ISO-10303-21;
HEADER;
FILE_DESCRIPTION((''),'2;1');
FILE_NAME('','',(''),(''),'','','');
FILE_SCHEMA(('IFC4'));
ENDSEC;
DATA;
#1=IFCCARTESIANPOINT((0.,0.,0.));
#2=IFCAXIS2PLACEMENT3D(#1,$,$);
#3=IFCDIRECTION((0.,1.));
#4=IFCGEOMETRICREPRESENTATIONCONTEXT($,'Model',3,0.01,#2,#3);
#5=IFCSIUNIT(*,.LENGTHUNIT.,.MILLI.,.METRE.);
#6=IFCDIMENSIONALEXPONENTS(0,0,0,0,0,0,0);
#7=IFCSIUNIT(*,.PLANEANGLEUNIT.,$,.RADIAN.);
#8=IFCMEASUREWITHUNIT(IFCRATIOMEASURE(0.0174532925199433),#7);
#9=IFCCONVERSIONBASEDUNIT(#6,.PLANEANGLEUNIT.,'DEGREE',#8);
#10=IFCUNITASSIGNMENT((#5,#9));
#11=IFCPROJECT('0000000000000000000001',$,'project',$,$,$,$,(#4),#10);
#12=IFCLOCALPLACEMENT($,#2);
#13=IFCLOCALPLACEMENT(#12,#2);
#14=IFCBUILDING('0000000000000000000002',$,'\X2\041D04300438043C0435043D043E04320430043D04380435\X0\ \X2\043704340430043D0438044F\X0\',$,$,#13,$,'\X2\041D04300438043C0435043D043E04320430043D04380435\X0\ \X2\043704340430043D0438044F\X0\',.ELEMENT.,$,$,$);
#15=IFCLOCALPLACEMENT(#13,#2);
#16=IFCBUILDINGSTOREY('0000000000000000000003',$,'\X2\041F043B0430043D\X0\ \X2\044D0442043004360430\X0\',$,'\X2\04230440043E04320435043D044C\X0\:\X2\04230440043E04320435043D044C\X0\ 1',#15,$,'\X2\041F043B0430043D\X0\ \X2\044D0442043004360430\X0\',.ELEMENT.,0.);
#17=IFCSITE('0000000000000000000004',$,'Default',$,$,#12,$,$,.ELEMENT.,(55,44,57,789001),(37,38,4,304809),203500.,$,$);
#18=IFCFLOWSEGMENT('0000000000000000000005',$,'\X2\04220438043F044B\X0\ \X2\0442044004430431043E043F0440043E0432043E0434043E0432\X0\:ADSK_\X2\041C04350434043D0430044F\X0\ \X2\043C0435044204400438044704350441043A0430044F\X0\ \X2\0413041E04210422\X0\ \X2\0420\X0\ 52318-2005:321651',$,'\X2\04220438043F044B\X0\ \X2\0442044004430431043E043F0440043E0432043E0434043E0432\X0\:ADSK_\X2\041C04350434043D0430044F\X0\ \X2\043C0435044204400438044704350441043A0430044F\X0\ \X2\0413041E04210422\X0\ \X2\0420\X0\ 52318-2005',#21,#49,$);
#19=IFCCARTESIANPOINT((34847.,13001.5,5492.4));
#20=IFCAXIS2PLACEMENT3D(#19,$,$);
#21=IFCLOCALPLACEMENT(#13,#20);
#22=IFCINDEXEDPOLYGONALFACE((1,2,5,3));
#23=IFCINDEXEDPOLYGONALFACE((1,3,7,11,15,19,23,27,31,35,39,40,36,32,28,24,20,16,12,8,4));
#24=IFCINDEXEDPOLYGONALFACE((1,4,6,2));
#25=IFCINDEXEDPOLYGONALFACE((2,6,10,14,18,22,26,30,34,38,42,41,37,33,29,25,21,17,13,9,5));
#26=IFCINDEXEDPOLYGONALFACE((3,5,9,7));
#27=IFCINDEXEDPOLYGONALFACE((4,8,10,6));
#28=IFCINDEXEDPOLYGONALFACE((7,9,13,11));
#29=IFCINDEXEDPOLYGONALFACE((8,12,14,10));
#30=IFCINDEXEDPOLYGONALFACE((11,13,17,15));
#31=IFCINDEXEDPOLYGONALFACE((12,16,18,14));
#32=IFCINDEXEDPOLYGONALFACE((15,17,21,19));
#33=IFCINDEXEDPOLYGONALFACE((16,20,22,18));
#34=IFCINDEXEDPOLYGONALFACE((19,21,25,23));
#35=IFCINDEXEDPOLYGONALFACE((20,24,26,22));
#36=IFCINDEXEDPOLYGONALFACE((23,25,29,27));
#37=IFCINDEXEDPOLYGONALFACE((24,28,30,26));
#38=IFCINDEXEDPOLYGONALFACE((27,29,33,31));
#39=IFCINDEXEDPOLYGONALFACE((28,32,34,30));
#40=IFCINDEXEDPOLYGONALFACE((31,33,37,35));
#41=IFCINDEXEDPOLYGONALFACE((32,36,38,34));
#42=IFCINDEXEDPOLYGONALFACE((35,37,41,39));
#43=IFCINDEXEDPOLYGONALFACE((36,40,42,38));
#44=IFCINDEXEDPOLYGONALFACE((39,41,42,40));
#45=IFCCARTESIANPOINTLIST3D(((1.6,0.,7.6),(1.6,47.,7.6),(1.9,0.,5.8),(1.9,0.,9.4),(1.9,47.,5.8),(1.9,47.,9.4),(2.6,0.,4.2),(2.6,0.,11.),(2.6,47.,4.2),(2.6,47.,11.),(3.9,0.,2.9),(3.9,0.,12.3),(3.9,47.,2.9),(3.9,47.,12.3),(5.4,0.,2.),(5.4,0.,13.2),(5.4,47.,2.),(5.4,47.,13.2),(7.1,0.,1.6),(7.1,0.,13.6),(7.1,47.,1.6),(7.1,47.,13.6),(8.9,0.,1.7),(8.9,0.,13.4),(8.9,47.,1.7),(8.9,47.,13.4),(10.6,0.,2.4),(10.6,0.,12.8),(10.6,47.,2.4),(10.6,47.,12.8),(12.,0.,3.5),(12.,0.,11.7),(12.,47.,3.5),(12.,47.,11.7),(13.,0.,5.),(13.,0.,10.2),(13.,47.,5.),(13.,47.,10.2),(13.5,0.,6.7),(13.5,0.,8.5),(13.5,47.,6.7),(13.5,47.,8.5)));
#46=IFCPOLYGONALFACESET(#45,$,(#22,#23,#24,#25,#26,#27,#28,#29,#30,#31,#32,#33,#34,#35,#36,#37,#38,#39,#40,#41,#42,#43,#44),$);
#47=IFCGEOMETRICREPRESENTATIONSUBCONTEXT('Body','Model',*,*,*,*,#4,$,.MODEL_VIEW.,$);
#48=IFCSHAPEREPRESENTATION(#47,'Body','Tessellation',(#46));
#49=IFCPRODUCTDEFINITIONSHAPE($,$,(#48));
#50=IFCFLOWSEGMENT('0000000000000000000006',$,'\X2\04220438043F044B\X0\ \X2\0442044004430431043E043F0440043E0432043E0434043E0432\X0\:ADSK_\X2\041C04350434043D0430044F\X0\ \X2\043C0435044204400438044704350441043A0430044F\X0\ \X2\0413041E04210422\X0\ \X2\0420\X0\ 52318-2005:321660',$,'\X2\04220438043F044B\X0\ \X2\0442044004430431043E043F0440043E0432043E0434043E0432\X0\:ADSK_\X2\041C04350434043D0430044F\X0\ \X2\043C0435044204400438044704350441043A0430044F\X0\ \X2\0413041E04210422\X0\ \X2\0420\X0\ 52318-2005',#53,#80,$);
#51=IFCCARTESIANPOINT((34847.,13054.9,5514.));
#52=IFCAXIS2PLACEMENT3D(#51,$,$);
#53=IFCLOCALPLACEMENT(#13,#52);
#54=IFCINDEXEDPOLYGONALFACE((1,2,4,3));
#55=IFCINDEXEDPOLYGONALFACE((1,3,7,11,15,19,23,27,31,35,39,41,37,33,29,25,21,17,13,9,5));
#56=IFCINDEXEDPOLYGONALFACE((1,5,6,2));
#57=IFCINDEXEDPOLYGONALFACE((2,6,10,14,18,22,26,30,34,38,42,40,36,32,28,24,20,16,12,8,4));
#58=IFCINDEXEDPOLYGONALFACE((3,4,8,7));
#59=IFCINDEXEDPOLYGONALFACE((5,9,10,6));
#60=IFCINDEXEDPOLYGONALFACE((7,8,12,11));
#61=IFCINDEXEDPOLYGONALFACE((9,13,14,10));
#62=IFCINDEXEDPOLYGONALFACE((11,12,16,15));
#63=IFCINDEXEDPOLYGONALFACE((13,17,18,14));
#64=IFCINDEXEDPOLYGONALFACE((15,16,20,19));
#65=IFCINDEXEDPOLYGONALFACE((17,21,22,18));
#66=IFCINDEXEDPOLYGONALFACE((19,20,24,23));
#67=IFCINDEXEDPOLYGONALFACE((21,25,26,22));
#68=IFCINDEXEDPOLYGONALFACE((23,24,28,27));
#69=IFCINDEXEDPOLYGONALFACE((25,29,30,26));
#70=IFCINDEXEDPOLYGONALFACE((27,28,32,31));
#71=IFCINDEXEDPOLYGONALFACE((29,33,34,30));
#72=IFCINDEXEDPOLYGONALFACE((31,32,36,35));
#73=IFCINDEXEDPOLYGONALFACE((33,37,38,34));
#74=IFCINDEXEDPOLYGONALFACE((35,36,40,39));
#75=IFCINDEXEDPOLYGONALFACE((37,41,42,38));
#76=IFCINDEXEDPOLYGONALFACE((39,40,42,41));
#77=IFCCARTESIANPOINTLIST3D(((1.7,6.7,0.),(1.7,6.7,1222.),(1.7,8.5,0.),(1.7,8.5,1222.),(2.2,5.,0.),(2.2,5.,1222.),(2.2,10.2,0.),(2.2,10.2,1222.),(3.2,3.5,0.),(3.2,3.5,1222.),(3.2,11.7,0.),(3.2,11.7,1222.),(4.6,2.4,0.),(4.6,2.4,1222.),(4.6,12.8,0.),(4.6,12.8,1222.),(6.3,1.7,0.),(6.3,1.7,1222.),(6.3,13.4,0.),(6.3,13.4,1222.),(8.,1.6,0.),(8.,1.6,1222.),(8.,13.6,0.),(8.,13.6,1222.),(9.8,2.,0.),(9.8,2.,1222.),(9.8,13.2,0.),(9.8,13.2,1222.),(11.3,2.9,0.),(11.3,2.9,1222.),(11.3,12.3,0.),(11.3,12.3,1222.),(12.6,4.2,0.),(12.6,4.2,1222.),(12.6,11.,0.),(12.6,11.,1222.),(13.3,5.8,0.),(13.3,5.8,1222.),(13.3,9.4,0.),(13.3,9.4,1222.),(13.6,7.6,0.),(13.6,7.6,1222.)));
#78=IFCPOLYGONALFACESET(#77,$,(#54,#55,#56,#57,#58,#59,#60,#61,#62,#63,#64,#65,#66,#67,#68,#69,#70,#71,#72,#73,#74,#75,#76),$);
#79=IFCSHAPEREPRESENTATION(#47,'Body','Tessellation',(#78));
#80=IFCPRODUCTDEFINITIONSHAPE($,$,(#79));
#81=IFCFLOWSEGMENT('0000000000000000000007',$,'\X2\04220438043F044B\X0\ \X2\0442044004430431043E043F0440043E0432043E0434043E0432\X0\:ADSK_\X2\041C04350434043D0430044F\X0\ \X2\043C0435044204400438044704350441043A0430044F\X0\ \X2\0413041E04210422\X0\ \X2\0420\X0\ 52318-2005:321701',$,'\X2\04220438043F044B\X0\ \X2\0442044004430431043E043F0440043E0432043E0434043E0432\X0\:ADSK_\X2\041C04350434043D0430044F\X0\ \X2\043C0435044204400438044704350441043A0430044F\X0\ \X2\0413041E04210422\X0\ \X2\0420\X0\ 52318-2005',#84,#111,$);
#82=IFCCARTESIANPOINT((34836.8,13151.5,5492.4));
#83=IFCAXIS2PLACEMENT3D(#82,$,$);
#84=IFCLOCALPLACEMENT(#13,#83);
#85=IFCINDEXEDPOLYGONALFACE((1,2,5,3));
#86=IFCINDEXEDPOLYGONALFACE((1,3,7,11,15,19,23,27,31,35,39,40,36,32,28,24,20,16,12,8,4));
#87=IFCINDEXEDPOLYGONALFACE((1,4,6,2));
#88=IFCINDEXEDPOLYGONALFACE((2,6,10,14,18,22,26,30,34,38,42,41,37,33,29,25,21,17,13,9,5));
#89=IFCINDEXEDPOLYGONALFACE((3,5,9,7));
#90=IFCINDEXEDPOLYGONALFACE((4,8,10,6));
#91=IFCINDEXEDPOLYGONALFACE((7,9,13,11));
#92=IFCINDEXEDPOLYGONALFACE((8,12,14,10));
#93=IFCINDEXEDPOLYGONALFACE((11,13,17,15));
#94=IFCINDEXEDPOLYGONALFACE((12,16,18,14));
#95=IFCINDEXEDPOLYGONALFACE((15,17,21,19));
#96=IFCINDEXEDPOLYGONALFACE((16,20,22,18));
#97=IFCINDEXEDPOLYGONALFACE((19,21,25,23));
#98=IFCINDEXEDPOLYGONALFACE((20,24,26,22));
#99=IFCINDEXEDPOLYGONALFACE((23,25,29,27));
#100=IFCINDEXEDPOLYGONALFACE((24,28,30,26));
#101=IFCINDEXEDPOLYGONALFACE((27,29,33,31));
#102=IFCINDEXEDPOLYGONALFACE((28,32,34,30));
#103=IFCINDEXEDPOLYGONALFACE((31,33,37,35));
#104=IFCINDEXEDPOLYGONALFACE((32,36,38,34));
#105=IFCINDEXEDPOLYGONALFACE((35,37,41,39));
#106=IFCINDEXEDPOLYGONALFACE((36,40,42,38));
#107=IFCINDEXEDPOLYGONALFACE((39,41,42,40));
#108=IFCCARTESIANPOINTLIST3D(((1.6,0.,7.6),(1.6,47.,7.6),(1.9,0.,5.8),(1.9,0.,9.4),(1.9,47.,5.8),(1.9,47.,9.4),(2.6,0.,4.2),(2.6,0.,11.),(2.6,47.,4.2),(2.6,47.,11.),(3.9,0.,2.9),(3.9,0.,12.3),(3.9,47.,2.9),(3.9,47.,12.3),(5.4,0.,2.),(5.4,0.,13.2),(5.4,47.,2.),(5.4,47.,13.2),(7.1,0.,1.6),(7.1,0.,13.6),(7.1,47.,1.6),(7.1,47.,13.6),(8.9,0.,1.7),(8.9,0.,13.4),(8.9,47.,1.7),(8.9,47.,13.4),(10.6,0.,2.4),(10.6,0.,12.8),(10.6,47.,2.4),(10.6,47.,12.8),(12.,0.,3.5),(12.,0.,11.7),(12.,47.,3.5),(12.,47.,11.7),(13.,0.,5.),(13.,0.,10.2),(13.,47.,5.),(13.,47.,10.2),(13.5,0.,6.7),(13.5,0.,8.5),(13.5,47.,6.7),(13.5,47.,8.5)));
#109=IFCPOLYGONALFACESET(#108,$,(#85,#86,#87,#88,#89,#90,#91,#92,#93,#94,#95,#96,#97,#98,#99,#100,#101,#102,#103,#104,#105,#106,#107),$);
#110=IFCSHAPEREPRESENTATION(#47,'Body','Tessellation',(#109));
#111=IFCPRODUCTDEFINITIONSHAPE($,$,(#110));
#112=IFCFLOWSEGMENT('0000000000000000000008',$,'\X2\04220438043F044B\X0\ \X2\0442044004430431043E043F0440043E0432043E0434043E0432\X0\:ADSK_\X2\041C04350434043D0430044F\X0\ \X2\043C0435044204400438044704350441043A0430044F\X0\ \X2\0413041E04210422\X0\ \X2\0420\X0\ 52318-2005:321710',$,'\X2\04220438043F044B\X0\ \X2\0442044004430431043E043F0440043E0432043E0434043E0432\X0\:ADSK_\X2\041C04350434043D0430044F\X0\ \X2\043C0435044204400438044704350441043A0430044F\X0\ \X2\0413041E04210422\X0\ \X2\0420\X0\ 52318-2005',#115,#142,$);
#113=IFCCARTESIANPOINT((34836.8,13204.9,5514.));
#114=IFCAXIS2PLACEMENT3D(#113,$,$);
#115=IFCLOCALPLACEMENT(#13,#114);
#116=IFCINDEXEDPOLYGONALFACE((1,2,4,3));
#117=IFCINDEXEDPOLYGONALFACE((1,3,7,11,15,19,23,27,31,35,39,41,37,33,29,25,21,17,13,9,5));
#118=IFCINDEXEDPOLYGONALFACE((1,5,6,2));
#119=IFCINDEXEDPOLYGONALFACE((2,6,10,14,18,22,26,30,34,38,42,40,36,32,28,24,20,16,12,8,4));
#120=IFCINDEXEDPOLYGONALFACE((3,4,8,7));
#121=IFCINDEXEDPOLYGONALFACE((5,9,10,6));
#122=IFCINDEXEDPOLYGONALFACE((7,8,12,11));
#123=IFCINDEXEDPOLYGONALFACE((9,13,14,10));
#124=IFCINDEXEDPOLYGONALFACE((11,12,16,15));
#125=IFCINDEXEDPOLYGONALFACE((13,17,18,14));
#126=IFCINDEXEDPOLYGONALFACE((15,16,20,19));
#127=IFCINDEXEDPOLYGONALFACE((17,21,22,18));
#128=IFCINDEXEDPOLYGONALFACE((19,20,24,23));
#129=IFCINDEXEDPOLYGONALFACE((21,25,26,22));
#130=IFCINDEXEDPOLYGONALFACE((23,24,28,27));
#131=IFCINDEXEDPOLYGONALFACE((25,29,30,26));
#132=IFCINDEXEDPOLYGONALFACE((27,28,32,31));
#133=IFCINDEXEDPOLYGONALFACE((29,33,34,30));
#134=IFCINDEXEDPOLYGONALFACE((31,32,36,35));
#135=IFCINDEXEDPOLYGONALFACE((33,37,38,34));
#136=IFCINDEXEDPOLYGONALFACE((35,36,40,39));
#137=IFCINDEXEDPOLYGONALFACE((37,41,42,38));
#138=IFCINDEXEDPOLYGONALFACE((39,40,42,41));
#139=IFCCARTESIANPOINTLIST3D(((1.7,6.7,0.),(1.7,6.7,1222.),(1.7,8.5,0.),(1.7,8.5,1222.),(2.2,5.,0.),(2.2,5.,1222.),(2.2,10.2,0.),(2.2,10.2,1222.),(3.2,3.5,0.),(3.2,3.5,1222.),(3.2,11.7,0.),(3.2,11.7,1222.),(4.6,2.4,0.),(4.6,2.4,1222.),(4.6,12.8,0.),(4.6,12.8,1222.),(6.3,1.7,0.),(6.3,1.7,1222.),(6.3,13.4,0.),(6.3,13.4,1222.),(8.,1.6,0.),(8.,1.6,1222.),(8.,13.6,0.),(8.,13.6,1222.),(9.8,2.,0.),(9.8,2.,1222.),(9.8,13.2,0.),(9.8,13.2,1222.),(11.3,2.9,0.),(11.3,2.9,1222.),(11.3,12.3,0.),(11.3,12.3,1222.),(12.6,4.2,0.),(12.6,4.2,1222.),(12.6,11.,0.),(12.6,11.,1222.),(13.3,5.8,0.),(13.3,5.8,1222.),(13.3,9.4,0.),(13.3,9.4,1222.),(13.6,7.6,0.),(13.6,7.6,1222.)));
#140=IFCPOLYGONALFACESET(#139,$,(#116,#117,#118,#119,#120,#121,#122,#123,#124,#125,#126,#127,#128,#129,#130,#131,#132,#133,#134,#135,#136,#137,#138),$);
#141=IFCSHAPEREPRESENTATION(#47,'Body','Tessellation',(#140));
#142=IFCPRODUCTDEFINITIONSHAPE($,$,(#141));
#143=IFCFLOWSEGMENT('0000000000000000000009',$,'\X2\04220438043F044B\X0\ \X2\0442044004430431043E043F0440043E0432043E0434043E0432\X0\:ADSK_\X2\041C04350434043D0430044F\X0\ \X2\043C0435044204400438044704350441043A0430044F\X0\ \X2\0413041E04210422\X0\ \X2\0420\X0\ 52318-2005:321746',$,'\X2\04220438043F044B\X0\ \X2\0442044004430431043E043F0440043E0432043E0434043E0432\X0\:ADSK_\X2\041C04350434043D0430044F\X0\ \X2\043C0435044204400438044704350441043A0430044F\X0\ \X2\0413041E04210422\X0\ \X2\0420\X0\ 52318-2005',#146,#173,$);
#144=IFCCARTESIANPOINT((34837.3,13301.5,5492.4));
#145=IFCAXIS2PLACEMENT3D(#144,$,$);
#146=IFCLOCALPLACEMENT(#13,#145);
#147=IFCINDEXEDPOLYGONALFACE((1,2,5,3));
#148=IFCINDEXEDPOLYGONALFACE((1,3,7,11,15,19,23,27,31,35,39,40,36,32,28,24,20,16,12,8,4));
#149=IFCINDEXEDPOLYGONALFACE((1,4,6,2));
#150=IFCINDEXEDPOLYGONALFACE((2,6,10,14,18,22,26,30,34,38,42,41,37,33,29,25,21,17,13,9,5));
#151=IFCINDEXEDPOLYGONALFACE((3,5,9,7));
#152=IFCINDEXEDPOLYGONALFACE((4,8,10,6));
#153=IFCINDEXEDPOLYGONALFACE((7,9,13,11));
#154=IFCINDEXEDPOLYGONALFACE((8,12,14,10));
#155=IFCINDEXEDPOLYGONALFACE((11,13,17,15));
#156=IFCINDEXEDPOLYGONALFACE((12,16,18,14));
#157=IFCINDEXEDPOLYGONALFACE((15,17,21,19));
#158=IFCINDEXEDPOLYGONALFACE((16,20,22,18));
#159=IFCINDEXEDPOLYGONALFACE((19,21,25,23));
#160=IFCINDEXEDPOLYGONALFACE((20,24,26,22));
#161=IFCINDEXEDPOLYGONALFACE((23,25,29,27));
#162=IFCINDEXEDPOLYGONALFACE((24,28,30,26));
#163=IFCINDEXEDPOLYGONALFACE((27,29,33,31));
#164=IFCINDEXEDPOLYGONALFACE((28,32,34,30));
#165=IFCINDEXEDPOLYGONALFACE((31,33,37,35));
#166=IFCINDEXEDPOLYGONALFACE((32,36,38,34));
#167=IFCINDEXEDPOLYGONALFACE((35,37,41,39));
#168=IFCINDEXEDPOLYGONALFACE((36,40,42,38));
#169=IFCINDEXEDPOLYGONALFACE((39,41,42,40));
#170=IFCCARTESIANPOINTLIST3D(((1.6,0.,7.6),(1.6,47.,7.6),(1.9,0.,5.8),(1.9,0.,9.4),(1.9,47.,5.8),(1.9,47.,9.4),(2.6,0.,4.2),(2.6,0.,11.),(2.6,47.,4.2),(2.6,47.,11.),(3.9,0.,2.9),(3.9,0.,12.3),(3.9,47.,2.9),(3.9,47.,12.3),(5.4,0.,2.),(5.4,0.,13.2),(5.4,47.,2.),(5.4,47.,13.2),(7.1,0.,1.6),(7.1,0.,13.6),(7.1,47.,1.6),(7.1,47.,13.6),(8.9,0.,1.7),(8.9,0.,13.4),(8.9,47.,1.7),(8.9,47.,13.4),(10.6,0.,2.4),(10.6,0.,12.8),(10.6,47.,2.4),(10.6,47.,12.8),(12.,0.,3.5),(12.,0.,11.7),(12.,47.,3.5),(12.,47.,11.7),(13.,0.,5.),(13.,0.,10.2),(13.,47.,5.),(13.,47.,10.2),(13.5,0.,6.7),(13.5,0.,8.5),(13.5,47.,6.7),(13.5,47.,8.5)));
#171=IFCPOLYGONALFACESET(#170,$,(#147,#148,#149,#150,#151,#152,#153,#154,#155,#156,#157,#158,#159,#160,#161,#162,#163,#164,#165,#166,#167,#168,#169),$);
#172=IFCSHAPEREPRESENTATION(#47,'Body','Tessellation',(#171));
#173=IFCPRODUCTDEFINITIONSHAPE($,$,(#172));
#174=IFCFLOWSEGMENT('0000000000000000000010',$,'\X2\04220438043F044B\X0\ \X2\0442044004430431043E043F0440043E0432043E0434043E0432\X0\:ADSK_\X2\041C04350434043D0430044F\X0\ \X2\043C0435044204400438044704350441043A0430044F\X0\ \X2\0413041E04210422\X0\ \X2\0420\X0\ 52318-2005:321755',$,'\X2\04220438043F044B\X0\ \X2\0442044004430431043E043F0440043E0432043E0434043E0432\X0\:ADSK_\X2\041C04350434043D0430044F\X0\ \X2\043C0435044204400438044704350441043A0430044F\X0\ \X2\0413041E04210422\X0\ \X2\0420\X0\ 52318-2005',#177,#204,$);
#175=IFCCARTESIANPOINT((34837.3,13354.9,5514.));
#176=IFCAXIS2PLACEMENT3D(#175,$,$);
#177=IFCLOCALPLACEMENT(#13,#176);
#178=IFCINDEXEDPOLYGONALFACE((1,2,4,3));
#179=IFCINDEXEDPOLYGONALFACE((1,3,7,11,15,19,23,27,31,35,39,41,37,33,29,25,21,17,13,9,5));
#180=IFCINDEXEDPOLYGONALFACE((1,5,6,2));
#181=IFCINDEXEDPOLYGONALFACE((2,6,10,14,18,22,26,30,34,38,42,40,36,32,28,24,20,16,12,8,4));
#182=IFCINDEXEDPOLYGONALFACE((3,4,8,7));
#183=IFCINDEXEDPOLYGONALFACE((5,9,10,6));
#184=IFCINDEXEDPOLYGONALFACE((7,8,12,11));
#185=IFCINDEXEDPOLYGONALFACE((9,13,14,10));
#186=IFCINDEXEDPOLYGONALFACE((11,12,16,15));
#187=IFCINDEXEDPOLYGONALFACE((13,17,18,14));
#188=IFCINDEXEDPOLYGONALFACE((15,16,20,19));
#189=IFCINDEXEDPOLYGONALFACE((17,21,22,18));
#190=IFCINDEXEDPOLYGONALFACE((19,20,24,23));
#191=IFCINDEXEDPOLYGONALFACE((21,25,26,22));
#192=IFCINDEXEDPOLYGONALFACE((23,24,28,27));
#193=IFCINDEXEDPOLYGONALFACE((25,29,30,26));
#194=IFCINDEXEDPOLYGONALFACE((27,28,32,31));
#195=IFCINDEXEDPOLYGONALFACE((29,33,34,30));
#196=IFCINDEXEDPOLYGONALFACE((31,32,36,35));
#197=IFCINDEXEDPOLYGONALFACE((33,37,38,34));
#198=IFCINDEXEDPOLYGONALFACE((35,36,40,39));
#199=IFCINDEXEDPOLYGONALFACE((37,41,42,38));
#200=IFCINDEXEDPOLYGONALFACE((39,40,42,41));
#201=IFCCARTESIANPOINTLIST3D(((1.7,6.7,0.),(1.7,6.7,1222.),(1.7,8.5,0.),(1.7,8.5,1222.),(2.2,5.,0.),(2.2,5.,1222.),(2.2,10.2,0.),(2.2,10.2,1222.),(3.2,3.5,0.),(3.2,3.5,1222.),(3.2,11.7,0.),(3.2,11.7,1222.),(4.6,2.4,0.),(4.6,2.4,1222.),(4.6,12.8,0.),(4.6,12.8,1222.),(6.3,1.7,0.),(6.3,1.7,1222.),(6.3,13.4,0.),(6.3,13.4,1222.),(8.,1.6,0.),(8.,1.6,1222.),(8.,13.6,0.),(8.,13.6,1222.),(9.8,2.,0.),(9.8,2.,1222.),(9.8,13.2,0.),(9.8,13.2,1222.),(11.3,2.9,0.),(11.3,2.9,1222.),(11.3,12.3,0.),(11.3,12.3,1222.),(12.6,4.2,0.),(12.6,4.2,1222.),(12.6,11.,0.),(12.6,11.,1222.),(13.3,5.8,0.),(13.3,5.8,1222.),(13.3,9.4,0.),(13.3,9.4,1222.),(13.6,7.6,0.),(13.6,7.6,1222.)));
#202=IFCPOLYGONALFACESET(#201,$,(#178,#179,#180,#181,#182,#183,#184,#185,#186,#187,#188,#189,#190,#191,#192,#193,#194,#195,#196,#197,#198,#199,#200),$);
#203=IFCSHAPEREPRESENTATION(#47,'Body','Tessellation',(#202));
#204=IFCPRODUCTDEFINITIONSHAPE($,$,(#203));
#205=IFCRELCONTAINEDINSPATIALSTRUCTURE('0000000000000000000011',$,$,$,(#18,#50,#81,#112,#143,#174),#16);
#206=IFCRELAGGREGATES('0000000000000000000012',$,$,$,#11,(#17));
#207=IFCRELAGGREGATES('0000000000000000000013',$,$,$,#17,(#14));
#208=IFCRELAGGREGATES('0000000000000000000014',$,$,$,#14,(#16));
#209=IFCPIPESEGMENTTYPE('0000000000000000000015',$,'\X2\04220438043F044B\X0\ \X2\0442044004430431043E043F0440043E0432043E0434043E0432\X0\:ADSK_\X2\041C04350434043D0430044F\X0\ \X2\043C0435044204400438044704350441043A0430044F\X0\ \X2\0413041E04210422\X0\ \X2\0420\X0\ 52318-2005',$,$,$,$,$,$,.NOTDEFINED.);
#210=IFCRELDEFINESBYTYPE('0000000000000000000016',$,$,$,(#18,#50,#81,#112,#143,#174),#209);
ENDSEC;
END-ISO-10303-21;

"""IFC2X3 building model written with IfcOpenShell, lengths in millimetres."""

from ifc_helpers import new_model, entity, si_unit, converted_unit, direction, frame, frame_2d, origin, origin_2d_with_axis, place, context, subcontext, project, spatial, circle, extrude, type_object, element, save


model = new_model("IFC2X3")

# Units and contexts
model_context = context("Model", 3, precision=0.01, world=origin(), true_north=direction((0.0, 1.0)))
body_context = subcontext(model_context, "Body", "Model", "MODEL_VIEW")
ifc_project = project(units=[si_unit("LENGTHUNIT", "METRE", prefix="MILLI"), converted_unit("PLANEANGLEUNIT", "DEGREE", entity("IfcRatioMeasure", 0.0174532925199433), si_unit("PLANEANGLEUNIT", "RADIAN"), dimensions=[0, 0, 0, 0, 0, 0, 0])], contexts=[model_context])

# Site, building, storey
site_placement = place(None, frame((0.0, 0.0, 0.0)))
site = spatial("IfcSite", under=ifc_project, at=site_placement, Name="Default", CompositionType="ELEMENT", RefLatitude=(55, 44, 57, 789001), RefLongitude=(37, 38, 4, 304809), RefElevation=203500.0)
building_placement = place(site_placement, origin())
building = spatial("IfcBuilding", under=site, at=building_placement, Name="Наименование здания", LongName="Наименование здания", CompositionType="ELEMENT")
storey_placement = place(building_placement, origin())
storey = spatial("IfcBuildingStorey", under=building, at=storey_placement, Name="План этажа", ObjectType="Уровень:Уровень 1", LongName="План этажа", CompositionType="ELEMENT", Elevation=0.0)

# Flow segments
pipe_segment_type = type_object("IfcPipeSegmentType", Name="Типы трубопроводов:ADSK_Медная метрическая ГОСТ Р 52318-2005", PredefinedType="NOTDEFINED")
flow_segment_1_placement = place(building_placement, frame((34847.0, 13001.5, 5492.4)))
element("IfcFlowSegment", 1, at=flow_segment_1_placement, inside=storey, type_object=pipe_segment_type, Name="Типы трубопроводов:ADSK_Медная метрическая ГОСТ Р 52318-2005:321651", ObjectType="Типы трубопроводов:ADSK_Медная метрическая ГОСТ Р 52318-2005", context=body_context, shape_type="SweptSolid", body=[
    extrude(circle(Radius=6.0, at=frame_2d((0.0, 0.0), x_axis=(1.0, 0.0))), frame((7.6, 0.0, 7.6), z_axis=(0.0, 1.0, 0.0), x_axis=(-1.0, 0.0, 0.0)), (0.0, 0.0, 1.0), 47.0),
])
flow_segment_2_placement = place(building_placement, frame((34847.0, 13054.9, 5514.0)))
element("IfcFlowSegment", 2, at=flow_segment_2_placement, inside=storey, type_object=pipe_segment_type, Name="Типы трубопроводов:ADSK_Медная метрическая ГОСТ Р 52318-2005:321660", ObjectType="Типы трубопроводов:ADSK_Медная метрическая ГОСТ Р 52318-2005", context=body_context, shape_type="SweptSolid", body=[
    extrude(circle(Radius=6.0, at=frame_2d((0.0, 0.0), x_axis=(1.0, 0.0))), frame((7.6, 7.6, 0.0)), (0.0, 0.0, 1.0), 1222.0),
])
flow_segment_3_placement = place(building_placement, frame((34836.8, 13151.5, 5492.4)))
element("IfcFlowSegment", 3, at=flow_segment_3_placement, inside=storey, type_object=pipe_segment_type, Name="Типы трубопроводов:ADSK_Медная метрическая ГОСТ Р 52318-2005:321701", ObjectType="Типы трубопроводов:ADSK_Медная метрическая ГОСТ Р 52318-2005", context=body_context, shape_type="SweptSolid", body=[
    extrude(circle(Radius=6.0, at=frame_2d((0.0, 0.0), x_axis=(1.0, 0.0))), frame((7.6, 0.0, 7.6), z_axis=(0.0, 1.0, 0.0), x_axis=(-1.0, 0.0, 0.0)), (0.0, 0.0, 1.0), 47.0),
])
flow_segment_4_placement = place(building_placement, frame((34836.8, 13204.9, 5514.0)))
element("IfcFlowSegment", 4, at=flow_segment_4_placement, inside=storey, type_object=pipe_segment_type, Name="Типы трубопроводов:ADSK_Медная метрическая ГОСТ Р 52318-2005:321710", ObjectType="Типы трубопроводов:ADSK_Медная метрическая ГОСТ Р 52318-2005", context=body_context, shape_type="SweptSolid", body=[
    extrude(circle(Radius=6.0, at=origin_2d_with_axis()), frame((7.6, 7.6, 0.0)), (0.0, 0.0, 1.0), 1222.0),
])
flow_segment_5_placement = place(building_placement, frame((34837.3, 13301.5, 5492.4)))
element("IfcFlowSegment", 5, at=flow_segment_5_placement, inside=storey, type_object=pipe_segment_type, Name="Типы трубопроводов:ADSK_Медная метрическая ГОСТ Р 52318-2005:321746", ObjectType="Типы трубопроводов:ADSK_Медная метрическая ГОСТ Р 52318-2005", context=body_context, shape_type="SweptSolid", body=[
    extrude(circle(Radius=6.0, at=frame_2d((0.0, 0.0), x_axis=(1.0, 0.0))), frame((7.6, 0.0, 7.6), z_axis=(0.0, 1.0, 0.0), x_axis=(-1.0, 0.0, 0.0)), (0.0, 0.0, 1.0), 47.0),
])
flow_segment_6_placement = place(building_placement, frame((34837.3, 13354.9, 5514.0)))
element("IfcFlowSegment", 6, at=flow_segment_6_placement, inside=storey, type_object=pipe_segment_type, Name="Типы трубопроводов:ADSK_Медная метрическая ГОСТ Р 52318-2005:321755", ObjectType="Типы трубопроводов:ADSK_Медная метрическая ГОСТ Р 52318-2005", context=body_context, shape_type="SweptSolid", body=[
    extrude(circle(Radius=6.0, at=origin_2d_with_axis()), frame((7.6, 7.6, 0.0)), (0.0, 0.0, 1.0), 1222.0),
])

save(model, "model.ifc")
